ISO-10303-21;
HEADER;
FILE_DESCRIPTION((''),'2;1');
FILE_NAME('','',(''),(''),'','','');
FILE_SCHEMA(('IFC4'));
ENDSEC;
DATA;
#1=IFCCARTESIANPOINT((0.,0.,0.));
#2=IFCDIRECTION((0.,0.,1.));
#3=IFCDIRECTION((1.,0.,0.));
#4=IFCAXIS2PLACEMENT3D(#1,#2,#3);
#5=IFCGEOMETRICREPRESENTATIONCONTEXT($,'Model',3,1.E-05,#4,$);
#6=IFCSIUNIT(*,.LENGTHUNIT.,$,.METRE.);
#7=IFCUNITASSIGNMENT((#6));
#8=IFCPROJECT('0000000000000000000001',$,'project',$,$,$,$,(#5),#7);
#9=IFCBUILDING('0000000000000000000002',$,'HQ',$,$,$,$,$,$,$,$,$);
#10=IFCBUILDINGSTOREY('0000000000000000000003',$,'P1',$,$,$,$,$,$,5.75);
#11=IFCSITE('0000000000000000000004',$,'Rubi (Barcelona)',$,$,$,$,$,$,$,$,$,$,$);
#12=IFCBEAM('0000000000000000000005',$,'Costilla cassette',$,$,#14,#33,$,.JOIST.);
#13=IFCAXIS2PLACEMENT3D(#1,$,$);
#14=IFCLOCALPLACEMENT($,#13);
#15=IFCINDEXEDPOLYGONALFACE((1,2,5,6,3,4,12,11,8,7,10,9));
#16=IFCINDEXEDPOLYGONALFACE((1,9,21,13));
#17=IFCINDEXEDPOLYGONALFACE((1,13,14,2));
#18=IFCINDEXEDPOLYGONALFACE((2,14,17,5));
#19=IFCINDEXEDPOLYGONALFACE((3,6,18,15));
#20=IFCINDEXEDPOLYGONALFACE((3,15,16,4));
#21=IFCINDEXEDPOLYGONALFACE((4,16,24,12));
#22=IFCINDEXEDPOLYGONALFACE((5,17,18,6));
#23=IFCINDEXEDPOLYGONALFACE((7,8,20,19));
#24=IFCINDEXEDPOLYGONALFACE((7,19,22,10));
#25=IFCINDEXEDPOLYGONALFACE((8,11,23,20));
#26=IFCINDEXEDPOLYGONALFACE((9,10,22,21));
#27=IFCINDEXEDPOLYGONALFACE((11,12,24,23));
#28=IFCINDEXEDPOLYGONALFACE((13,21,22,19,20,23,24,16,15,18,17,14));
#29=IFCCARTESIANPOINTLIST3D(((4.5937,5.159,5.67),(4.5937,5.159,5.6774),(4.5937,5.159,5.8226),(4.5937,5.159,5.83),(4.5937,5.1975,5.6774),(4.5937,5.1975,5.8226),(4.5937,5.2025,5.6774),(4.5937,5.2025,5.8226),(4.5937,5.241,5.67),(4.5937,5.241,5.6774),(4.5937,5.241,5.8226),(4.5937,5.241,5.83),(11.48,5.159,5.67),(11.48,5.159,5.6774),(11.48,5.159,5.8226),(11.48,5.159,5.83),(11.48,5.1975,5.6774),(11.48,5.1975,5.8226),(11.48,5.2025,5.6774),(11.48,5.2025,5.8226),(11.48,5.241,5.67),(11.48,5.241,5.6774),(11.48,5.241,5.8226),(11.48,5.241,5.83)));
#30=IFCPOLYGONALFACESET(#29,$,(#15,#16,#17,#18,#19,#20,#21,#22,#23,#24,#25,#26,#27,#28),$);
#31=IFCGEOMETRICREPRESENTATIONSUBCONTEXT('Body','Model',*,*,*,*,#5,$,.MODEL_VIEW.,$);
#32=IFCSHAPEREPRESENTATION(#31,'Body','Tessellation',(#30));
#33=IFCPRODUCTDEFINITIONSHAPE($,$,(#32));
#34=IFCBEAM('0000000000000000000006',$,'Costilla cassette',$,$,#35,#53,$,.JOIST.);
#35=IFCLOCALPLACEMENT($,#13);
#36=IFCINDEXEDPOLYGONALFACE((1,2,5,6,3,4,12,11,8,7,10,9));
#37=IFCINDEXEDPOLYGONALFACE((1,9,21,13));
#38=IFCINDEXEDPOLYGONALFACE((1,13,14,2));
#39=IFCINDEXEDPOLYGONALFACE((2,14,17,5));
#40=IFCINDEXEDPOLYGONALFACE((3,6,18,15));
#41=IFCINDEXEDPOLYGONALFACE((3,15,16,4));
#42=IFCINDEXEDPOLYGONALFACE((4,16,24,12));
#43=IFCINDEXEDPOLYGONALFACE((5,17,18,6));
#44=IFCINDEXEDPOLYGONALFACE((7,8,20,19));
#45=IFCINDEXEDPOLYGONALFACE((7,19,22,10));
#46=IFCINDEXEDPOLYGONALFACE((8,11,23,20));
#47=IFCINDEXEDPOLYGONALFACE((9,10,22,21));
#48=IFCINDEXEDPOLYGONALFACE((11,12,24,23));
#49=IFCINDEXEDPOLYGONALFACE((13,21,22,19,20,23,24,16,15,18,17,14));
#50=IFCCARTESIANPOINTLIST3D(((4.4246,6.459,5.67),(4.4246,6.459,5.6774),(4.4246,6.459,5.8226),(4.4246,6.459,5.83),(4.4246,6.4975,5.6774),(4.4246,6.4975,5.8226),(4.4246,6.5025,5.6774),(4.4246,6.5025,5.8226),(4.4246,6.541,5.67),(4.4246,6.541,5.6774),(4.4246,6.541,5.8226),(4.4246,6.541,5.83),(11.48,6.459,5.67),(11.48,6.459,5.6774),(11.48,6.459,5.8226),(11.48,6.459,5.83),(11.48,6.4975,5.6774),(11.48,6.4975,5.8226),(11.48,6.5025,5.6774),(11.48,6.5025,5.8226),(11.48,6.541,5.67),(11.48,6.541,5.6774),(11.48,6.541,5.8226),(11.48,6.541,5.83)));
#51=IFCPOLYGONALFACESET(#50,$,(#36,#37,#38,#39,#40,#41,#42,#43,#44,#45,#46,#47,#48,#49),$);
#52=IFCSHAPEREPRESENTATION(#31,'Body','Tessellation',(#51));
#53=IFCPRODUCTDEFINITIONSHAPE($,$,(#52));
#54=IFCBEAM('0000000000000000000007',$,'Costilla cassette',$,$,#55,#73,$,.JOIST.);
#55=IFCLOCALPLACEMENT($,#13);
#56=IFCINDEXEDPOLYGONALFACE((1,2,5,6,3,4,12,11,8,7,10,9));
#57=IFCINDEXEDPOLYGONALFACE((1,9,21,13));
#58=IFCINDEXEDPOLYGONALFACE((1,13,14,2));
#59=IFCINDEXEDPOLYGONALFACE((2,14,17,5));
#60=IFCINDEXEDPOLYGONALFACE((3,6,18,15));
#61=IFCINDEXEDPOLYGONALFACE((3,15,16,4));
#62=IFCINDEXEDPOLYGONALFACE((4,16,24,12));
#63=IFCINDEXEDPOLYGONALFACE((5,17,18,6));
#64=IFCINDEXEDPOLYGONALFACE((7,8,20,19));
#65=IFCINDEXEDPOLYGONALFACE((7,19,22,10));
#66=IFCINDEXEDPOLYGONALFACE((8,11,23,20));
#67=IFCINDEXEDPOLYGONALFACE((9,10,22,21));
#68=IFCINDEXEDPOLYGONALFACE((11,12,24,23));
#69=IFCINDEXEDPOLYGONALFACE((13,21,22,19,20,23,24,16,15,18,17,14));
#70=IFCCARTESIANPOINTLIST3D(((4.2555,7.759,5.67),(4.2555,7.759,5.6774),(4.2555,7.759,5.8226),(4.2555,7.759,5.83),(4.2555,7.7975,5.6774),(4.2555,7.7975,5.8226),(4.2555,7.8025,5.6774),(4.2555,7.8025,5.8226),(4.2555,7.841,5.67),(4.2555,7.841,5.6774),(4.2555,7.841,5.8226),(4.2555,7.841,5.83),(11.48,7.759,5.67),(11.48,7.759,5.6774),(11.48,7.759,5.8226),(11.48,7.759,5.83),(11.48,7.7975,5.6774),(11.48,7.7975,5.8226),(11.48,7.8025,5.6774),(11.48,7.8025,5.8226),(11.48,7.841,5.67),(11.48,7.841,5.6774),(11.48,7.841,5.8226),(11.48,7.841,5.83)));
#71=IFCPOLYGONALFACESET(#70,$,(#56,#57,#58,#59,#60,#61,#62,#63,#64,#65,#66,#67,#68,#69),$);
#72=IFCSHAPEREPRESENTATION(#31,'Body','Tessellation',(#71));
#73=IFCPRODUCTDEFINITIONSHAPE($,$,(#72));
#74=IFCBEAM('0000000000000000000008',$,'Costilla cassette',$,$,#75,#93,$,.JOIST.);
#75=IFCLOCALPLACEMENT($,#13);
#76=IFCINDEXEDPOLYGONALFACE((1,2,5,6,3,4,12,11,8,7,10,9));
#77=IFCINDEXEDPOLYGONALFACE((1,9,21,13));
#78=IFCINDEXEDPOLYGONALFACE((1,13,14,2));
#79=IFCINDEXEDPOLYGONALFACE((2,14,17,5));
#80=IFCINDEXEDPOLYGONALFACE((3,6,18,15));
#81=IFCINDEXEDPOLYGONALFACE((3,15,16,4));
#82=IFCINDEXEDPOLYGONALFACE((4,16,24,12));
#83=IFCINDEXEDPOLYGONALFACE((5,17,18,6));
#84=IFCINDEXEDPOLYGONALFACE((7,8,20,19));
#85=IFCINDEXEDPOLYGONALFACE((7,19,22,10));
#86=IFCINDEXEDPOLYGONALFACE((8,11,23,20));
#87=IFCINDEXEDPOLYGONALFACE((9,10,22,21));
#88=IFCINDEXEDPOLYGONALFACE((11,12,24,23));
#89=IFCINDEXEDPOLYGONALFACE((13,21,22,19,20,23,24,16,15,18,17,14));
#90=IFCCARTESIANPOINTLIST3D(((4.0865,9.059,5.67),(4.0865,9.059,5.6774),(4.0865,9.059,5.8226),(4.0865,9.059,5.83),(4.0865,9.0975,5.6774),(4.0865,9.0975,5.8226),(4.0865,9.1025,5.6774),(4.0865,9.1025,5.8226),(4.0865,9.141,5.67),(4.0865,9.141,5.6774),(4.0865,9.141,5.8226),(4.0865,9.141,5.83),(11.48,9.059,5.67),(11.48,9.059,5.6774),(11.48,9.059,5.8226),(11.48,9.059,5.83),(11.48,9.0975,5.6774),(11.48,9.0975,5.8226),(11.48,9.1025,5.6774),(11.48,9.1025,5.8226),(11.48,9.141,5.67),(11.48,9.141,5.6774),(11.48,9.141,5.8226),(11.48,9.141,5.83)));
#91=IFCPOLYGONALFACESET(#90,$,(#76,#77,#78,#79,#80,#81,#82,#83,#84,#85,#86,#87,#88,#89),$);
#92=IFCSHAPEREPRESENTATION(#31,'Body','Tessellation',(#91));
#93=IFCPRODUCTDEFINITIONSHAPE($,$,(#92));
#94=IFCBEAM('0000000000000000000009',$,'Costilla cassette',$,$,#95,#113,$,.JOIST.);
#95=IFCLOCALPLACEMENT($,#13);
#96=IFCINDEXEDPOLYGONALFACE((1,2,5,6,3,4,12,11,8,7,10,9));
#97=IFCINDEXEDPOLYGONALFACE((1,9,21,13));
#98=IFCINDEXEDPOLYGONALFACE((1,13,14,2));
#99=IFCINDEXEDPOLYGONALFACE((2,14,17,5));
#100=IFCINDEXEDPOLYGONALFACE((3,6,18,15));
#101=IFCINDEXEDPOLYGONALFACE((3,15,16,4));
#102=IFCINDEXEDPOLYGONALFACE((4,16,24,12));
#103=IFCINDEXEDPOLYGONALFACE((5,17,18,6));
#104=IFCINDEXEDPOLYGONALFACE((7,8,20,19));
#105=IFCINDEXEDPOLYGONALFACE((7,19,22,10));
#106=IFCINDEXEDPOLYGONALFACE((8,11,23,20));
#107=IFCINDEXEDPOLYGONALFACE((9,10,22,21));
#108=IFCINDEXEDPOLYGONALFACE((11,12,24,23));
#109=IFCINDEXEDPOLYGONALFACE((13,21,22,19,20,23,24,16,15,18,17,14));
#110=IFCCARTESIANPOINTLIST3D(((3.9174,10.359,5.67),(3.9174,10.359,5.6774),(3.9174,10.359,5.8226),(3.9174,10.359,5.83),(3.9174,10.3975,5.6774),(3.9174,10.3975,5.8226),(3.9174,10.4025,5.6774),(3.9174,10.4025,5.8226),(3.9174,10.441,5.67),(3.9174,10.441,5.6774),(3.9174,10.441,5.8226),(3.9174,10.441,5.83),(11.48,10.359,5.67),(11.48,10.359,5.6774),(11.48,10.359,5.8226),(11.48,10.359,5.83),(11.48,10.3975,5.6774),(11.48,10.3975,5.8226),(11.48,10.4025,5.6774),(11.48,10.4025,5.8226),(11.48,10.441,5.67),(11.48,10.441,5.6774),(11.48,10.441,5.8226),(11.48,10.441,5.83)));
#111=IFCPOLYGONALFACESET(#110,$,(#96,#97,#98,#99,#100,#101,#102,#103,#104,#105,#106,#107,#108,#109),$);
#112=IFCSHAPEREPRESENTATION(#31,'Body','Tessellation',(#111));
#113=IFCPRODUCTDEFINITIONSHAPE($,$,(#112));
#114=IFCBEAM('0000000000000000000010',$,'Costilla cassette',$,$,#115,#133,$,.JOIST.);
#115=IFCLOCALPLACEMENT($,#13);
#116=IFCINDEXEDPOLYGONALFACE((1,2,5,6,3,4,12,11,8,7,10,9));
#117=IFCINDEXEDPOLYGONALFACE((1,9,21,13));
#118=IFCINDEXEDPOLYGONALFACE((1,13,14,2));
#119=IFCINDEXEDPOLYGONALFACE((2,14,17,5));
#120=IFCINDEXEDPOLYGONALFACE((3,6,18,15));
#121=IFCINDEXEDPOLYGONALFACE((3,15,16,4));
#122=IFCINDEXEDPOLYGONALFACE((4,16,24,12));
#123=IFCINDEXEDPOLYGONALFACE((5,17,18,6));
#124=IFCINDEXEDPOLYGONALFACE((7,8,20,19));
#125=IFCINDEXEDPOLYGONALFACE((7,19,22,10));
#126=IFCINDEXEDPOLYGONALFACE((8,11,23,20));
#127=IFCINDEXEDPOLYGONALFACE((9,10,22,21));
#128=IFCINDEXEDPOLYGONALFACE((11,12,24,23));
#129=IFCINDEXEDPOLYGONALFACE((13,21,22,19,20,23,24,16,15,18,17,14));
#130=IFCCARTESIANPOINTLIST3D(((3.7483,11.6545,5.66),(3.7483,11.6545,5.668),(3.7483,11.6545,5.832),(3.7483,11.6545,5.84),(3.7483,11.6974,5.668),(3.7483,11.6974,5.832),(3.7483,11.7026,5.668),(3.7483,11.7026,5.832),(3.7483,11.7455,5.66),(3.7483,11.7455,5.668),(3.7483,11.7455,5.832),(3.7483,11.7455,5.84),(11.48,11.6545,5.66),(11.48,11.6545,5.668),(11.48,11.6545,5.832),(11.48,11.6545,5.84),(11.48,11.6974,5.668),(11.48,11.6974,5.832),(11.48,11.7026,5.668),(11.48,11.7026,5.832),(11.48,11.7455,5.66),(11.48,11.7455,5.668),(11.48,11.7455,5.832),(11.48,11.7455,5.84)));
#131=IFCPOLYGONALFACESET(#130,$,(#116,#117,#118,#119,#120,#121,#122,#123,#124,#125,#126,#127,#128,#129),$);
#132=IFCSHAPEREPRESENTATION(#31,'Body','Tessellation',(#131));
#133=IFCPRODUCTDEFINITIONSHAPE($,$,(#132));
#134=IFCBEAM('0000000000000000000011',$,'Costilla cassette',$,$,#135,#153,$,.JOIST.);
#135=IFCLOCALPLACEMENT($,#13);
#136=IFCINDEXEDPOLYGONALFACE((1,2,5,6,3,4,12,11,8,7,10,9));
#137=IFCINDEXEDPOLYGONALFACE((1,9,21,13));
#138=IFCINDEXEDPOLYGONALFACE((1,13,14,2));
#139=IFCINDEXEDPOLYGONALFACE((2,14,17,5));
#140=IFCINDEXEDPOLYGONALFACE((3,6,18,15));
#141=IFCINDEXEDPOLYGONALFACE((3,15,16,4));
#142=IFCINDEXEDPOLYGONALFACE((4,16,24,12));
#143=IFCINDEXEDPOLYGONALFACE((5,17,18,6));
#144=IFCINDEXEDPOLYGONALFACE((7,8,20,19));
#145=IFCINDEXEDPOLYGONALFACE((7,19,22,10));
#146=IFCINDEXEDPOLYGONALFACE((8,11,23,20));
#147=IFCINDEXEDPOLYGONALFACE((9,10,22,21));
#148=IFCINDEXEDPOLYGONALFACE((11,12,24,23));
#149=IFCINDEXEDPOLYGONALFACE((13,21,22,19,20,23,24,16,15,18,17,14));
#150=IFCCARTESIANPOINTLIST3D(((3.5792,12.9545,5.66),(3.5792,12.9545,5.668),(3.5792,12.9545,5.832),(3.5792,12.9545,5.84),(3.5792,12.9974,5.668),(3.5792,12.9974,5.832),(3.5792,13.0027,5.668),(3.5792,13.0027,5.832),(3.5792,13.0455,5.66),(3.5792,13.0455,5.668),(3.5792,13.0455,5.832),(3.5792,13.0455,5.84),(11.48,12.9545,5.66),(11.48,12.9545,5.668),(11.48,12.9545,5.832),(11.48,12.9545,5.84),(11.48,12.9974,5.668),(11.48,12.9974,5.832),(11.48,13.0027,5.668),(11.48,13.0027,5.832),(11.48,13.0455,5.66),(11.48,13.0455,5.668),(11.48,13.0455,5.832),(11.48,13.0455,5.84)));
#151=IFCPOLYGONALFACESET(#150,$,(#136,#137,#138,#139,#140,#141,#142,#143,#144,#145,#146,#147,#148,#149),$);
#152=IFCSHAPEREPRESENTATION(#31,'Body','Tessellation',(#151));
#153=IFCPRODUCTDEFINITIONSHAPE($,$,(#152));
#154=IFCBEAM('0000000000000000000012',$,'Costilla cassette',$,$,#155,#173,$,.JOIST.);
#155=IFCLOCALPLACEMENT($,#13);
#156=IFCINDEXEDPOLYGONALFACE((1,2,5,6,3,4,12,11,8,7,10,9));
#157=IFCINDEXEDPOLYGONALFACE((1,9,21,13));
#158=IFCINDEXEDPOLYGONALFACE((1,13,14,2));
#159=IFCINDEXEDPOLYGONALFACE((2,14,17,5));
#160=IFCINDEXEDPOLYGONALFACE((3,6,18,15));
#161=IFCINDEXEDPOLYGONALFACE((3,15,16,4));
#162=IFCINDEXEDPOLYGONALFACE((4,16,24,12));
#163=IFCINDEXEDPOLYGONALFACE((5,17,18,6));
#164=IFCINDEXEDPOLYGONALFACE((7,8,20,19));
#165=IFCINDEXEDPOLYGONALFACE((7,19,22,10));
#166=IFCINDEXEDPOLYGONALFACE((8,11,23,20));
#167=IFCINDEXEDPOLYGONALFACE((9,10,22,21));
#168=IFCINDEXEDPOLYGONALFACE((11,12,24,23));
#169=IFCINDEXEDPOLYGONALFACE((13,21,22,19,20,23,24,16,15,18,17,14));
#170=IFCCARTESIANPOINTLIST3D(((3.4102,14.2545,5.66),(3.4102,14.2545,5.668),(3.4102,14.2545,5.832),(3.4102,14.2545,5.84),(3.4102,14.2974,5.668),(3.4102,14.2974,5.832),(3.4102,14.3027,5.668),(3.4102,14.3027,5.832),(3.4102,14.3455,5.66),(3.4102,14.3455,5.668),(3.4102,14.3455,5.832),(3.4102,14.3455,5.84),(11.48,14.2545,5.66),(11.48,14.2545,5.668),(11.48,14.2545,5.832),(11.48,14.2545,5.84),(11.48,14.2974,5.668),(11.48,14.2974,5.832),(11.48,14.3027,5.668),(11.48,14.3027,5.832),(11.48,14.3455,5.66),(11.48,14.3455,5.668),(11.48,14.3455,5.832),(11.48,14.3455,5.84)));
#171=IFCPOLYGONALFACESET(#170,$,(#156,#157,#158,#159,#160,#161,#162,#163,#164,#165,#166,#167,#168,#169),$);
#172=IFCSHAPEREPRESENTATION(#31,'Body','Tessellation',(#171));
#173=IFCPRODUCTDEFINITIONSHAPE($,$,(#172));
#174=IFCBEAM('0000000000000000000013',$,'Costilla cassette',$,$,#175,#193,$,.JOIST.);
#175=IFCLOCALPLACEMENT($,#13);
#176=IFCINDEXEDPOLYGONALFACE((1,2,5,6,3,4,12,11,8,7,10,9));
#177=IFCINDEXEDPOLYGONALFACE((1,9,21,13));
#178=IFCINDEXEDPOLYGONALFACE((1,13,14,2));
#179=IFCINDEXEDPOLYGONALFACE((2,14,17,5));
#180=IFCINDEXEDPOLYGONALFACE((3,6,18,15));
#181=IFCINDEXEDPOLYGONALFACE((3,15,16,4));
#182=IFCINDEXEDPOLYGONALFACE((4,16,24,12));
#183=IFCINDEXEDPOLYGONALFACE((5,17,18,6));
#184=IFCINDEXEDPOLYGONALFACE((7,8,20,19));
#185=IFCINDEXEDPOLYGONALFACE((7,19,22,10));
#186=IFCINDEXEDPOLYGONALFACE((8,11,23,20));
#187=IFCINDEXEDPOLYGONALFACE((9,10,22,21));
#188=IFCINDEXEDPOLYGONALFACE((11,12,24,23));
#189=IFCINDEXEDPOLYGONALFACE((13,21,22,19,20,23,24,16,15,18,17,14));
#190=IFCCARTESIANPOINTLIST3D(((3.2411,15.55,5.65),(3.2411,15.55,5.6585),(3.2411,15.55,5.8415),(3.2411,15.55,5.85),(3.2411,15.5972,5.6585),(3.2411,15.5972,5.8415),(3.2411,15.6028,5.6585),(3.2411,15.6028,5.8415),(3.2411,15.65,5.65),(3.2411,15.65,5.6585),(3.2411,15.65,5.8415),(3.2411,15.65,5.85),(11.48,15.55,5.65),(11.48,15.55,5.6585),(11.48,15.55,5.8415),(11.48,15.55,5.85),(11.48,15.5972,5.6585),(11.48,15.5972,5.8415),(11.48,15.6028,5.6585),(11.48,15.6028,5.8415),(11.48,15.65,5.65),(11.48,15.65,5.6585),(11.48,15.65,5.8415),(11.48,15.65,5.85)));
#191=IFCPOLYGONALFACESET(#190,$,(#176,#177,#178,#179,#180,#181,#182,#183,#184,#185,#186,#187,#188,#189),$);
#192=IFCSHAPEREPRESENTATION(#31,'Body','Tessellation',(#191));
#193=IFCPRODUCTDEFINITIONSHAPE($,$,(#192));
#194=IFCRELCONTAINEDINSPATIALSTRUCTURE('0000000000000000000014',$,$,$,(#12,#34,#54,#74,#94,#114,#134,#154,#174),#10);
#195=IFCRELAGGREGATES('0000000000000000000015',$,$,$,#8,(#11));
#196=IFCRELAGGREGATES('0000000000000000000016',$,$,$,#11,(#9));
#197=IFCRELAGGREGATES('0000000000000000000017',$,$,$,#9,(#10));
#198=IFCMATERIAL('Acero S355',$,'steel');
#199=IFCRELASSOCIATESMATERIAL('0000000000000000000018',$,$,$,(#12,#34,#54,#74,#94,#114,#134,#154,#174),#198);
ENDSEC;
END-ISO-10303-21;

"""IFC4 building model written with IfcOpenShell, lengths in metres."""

from ifc_helpers import new_model, si_unit, frame, origin_with_axes, place, context, subcontext, project, spatial, i_section, extrude, material, element, save


model = new_model("IFC4")

# Units and contexts
model_context = context("Model", 3, precision=1e-05, world=origin_with_axes())
body_context = subcontext(model_context, "Body", "Model", "MODEL_VIEW")
ifc_project = project(units=[si_unit("LENGTHUNIT", "METRE")], contexts=[model_context])

# Site, building, storey
site = spatial("IfcSite", under=ifc_project, Name="Rubi (Barcelona)")
building = spatial("IfcBuilding", under=site, Name="HQ")
storey = spatial("IfcBuildingStorey", under=building, Name="P1", Elevation=5.75)

# Shared definitions
ifc_material = material(Name="Acero S355", Category="steel")

# Beams
beam_1_placement = place(None, origin_with_axes())
element("IfcBeam", 1, at=beam_1_placement, inside=storey, material=ifc_material, Name="Costilla cassette", PredefinedType="JOIST", context=body_context, shape_type="SweptSolid", body=[
    extrude(i_section(OverallWidth=0.082, OverallDepth=0.16, WebThickness=0.005, FlangeThickness=0.0074), frame((4.5937, 5.2, 5.75), z_axis=(1.0, 0.0, 0.0), x_axis=(0.0, 1.0, 0.0)), (0.0, 0.0, 1.0), 6.8863),
])
beam_2_placement = place(None, origin_with_axes())
element("IfcBeam", 2, at=beam_2_placement, inside=storey, material=ifc_material, Name="Costilla cassette", PredefinedType="JOIST", context=body_context, shape_type="SweptSolid", body=[
    extrude(i_section(OverallWidth=0.082, OverallDepth=0.16, WebThickness=0.005, FlangeThickness=0.0074), frame((4.4246, 6.5, 5.75), z_axis=(1.0, 0.0, 0.0), x_axis=(0.0, 1.0, 0.0)), (0.0, 0.0, 1.0), 7.0554),
])
beam_3_placement = place(None, origin_with_axes())
element("IfcBeam", 3, at=beam_3_placement, inside=storey, material=ifc_material, Name="Costilla cassette", PredefinedType="JOIST", context=body_context, shape_type="SweptSolid", body=[
    extrude(i_section(OverallWidth=0.082, OverallDepth=0.16, WebThickness=0.005, FlangeThickness=0.0074), frame((4.2555, 7.8, 5.75), z_axis=(1.0, 0.0, 0.0), x_axis=(0.0, 1.0, 0.0)), (0.0, 0.0, 1.0), 7.2245),
])
beam_4_placement = place(None, origin_with_axes())
element("IfcBeam", 4, at=beam_4_placement, inside=storey, material=ifc_material, Name="Costilla cassette", PredefinedType="JOIST", context=body_context, shape_type="SweptSolid", body=[
    extrude(i_section(OverallWidth=0.082, OverallDepth=0.16, WebThickness=0.005, FlangeThickness=0.0074), frame((4.0865, 9.1, 5.75), z_axis=(1.0, 0.0, 0.0), x_axis=(0.0, 1.0, 0.0)), (0.0, 0.0, 1.0), 7.3935),
])
beam_5_placement = place(None, origin_with_axes())
element("IfcBeam", 5, at=beam_5_placement, inside=storey, material=ifc_material, Name="Costilla cassette", PredefinedType="JOIST", context=body_context, shape_type="SweptSolid", body=[
    extrude(i_section(OverallWidth=0.082, OverallDepth=0.16, WebThickness=0.005, FlangeThickness=0.0074), frame((3.9174, 10.4, 5.75), z_axis=(1.0, 0.0, 0.0), x_axis=(0.0, 1.0, 0.0)), (0.0, 0.0, 1.0), 7.5626),
])
beam_6_placement = place(None, origin_with_axes())
element("IfcBeam", 6, at=beam_6_placement, inside=storey, material=ifc_material, Name="Costilla cassette", PredefinedType="JOIST", context=body_context, shape_type="SweptSolid", body=[
    extrude(i_section(OverallWidth=0.091, OverallDepth=0.18, WebThickness=0.0053, FlangeThickness=0.008), frame((3.7483, 11.7, 5.75), z_axis=(1.0, 0.0, 0.0), x_axis=(0.0, 1.0, 0.0)), (0.0, 0.0, 1.0), 7.7317),
])
beam_7_placement = place(None, origin_with_axes())
element("IfcBeam", 7, at=beam_7_placement, inside=storey, material=ifc_material, Name="Costilla cassette", PredefinedType="JOIST", context=body_context, shape_type="SweptSolid", body=[
    extrude(i_section(OverallWidth=0.091, OverallDepth=0.18, WebThickness=0.0053, FlangeThickness=0.008), frame((3.5792, 13.0, 5.75), z_axis=(1.0, 0.0, 0.0), x_axis=(0.0, 1.0, 0.0)), (0.0, 0.0, 1.0), 7.9008),
])
beam_8_placement = place(None, origin_with_axes())
element("IfcBeam", 8, at=beam_8_placement, inside=storey, material=ifc_material, Name="Costilla cassette", PredefinedType="JOIST", context=body_context, shape_type="SweptSolid", body=[
    extrude(i_section(OverallWidth=0.091, OverallDepth=0.18, WebThickness=0.0053, FlangeThickness=0.008), frame((3.4102, 14.3, 5.75), z_axis=(1.0, 0.0, 0.0), x_axis=(0.0, 1.0, 0.0)), (0.0, 0.0, 1.0), 8.0698),
])
beam_9_placement = place(None, origin_with_axes())
element("IfcBeam", 9, at=beam_9_placement, inside=storey, material=ifc_material, Name="Costilla cassette", PredefinedType="JOIST", context=body_context, shape_type="SweptSolid", body=[
    extrude(i_section(OverallWidth=0.1, OverallDepth=0.2, WebThickness=0.0056, FlangeThickness=0.0085), frame((3.2411, 15.6, 5.75), z_axis=(1.0, 0.0, 0.0), x_axis=(0.0, 1.0, 0.0)), (0.0, 0.0, 1.0), 8.2389),
])

save(model, "model.ifc")
